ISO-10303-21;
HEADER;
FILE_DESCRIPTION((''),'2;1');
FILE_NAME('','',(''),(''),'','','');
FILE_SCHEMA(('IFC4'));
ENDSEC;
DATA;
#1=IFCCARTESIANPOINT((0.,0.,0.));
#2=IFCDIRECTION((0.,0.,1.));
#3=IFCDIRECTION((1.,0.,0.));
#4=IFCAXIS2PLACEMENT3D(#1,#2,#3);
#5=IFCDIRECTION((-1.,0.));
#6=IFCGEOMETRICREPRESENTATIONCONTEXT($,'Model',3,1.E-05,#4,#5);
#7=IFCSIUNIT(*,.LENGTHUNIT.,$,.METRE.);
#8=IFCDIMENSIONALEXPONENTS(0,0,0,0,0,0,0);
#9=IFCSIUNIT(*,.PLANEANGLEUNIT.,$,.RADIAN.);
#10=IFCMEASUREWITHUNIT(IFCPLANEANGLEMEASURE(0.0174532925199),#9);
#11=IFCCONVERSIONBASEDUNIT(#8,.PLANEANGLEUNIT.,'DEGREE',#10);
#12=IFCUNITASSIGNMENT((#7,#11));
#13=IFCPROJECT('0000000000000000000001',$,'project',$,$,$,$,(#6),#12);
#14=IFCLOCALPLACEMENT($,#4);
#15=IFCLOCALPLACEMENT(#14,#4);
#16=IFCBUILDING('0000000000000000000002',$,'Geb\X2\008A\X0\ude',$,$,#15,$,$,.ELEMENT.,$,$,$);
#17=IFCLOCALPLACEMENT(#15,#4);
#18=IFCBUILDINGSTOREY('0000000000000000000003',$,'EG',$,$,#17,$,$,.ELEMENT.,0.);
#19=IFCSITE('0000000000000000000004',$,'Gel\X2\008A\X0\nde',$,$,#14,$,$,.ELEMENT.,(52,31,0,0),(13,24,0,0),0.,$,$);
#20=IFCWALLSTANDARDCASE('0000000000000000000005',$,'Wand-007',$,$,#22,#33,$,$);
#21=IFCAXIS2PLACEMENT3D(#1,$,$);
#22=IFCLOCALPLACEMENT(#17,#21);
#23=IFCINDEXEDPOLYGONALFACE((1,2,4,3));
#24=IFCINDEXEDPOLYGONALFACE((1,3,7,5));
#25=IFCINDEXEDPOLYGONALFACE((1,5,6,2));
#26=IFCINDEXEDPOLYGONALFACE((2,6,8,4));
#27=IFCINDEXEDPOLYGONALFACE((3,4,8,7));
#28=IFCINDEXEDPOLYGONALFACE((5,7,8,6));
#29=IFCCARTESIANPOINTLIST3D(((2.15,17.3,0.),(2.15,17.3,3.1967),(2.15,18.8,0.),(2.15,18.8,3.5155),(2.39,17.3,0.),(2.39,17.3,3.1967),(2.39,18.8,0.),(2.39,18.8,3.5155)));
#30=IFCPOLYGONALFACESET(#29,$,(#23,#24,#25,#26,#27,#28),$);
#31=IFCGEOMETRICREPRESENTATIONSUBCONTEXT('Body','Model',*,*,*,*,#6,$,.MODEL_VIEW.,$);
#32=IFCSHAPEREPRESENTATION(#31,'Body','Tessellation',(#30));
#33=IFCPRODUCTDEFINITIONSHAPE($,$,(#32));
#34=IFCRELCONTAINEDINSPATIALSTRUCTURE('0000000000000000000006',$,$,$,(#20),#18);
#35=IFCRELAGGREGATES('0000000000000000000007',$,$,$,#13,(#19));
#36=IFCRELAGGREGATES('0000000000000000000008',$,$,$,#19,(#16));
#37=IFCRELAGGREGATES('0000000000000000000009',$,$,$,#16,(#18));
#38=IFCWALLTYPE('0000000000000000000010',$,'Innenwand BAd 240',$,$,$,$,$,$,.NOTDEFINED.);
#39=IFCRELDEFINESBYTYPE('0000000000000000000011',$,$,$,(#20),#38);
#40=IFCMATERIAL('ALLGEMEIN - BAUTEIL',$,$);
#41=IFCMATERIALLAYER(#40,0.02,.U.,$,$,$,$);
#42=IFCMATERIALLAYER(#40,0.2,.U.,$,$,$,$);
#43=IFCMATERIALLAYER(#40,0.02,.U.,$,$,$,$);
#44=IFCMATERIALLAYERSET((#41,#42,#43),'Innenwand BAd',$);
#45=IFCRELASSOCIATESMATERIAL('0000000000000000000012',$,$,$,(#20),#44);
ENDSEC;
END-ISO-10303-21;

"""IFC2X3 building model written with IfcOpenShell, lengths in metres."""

from ifc_helpers import new_model, entity, si_unit, converted_unit, direction, frame, origin_with_axes, place, context, subcontext, project, spatial, polyline, outline, extrude, clip, halfspace, material, layer, layer_set, layer_usage, type_object, element, save


model = new_model("IFC2X3")

# Units and contexts
model_context = context("Model", 3, precision=1e-05, world=origin_with_axes(), true_north=direction((-1.0, 0.0)))
body_context = subcontext(model_context, "Body", "Model", "MODEL_VIEW")
ifc_project = project(units=[si_unit("LENGTHUNIT", "METRE"), converted_unit("PLANEANGLEUNIT", "DEGREE", entity("IfcPlaneAngleMeasure", 0.0174532925199), si_unit("PLANEANGLEUNIT", "RADIAN"), dimensions=[0, 0, 0, 0, 0, 0, 0])], contexts=[model_context])

# Site, building, storey
site_placement = place(None, origin_with_axes())
site = spatial("IfcSite", under=ifc_project, at=site_placement, Name="Gel\u008ande", CompositionType="ELEMENT", RefLatitude=(52, 31, 0, 0), RefLongitude=(13, 24, 0, 0), RefElevation=0.0)
building_placement = place(site_placement, origin_with_axes())
building = spatial("IfcBuilding", under=site, at=building_placement, Name="Geb\u008aude", CompositionType="ELEMENT")
storey_placement = place(building_placement, origin_with_axes())
storey = spatial("IfcBuildingStorey", under=building, at=storey_placement, Name="EG", CompositionType="ELEMENT", Elevation=0.0)

# Shared definitions
ifc_material_1 = material(Name="ALLGEMEIN - BAUTEIL")

# Wall
ifc_layer_1 = layer(ifc_material_1, 0.02, ventilated="UNKNOWN")
ifc_layer_2 = layer(ifc_material_1, 0.2, ventilated="UNKNOWN")
ifc_layer_3 = layer(ifc_material_1, 0.02, ventilated="UNKNOWN")
ifc_layer_set_1 = layer_set([ifc_layer_1, ifc_layer_2, ifc_layer_3], Name="Innenwand BAd")
wall_type_1 = type_object("IfcWallType", Name="Innenwand BAd 240", PredefinedType="NOTDEFINED")
ifc_layer_usage_1 = layer_usage(ifc_layer_set_1, "AXIS2", "NEGATIVE", 0.0)
wall_1_placement = place(storey_placement, frame((2.39, 18.8, 0.0), z_axis=(0.0, 0.0, 1.0), x_axis=(0.0, -1.0, 0.0)))
element("IfcWallStandardCase", 1, at=wall_1_placement, inside=storey, type_object=wall_type_1, material=ifc_layer_usage_1, Name="Wand-007", context=body_context, shape_type="Clipping", body=[
    clip(extrude(outline(polyline([(0.0, -0.24), (1.5, -0.24), (1.5, 0.0), (0.0, 0.0), (0.0, -0.24)])), origin_with_axes(), (0.0, 0.0, 1.0), 7.0), halfspace(frame((0.7149, 0.0, 3.3635), z_axis=(-0.207912, 0.0, -0.978148), x_axis=(0.978148, 0.0, -0.207912)), True)),
])

save(model, "model.ifc")
